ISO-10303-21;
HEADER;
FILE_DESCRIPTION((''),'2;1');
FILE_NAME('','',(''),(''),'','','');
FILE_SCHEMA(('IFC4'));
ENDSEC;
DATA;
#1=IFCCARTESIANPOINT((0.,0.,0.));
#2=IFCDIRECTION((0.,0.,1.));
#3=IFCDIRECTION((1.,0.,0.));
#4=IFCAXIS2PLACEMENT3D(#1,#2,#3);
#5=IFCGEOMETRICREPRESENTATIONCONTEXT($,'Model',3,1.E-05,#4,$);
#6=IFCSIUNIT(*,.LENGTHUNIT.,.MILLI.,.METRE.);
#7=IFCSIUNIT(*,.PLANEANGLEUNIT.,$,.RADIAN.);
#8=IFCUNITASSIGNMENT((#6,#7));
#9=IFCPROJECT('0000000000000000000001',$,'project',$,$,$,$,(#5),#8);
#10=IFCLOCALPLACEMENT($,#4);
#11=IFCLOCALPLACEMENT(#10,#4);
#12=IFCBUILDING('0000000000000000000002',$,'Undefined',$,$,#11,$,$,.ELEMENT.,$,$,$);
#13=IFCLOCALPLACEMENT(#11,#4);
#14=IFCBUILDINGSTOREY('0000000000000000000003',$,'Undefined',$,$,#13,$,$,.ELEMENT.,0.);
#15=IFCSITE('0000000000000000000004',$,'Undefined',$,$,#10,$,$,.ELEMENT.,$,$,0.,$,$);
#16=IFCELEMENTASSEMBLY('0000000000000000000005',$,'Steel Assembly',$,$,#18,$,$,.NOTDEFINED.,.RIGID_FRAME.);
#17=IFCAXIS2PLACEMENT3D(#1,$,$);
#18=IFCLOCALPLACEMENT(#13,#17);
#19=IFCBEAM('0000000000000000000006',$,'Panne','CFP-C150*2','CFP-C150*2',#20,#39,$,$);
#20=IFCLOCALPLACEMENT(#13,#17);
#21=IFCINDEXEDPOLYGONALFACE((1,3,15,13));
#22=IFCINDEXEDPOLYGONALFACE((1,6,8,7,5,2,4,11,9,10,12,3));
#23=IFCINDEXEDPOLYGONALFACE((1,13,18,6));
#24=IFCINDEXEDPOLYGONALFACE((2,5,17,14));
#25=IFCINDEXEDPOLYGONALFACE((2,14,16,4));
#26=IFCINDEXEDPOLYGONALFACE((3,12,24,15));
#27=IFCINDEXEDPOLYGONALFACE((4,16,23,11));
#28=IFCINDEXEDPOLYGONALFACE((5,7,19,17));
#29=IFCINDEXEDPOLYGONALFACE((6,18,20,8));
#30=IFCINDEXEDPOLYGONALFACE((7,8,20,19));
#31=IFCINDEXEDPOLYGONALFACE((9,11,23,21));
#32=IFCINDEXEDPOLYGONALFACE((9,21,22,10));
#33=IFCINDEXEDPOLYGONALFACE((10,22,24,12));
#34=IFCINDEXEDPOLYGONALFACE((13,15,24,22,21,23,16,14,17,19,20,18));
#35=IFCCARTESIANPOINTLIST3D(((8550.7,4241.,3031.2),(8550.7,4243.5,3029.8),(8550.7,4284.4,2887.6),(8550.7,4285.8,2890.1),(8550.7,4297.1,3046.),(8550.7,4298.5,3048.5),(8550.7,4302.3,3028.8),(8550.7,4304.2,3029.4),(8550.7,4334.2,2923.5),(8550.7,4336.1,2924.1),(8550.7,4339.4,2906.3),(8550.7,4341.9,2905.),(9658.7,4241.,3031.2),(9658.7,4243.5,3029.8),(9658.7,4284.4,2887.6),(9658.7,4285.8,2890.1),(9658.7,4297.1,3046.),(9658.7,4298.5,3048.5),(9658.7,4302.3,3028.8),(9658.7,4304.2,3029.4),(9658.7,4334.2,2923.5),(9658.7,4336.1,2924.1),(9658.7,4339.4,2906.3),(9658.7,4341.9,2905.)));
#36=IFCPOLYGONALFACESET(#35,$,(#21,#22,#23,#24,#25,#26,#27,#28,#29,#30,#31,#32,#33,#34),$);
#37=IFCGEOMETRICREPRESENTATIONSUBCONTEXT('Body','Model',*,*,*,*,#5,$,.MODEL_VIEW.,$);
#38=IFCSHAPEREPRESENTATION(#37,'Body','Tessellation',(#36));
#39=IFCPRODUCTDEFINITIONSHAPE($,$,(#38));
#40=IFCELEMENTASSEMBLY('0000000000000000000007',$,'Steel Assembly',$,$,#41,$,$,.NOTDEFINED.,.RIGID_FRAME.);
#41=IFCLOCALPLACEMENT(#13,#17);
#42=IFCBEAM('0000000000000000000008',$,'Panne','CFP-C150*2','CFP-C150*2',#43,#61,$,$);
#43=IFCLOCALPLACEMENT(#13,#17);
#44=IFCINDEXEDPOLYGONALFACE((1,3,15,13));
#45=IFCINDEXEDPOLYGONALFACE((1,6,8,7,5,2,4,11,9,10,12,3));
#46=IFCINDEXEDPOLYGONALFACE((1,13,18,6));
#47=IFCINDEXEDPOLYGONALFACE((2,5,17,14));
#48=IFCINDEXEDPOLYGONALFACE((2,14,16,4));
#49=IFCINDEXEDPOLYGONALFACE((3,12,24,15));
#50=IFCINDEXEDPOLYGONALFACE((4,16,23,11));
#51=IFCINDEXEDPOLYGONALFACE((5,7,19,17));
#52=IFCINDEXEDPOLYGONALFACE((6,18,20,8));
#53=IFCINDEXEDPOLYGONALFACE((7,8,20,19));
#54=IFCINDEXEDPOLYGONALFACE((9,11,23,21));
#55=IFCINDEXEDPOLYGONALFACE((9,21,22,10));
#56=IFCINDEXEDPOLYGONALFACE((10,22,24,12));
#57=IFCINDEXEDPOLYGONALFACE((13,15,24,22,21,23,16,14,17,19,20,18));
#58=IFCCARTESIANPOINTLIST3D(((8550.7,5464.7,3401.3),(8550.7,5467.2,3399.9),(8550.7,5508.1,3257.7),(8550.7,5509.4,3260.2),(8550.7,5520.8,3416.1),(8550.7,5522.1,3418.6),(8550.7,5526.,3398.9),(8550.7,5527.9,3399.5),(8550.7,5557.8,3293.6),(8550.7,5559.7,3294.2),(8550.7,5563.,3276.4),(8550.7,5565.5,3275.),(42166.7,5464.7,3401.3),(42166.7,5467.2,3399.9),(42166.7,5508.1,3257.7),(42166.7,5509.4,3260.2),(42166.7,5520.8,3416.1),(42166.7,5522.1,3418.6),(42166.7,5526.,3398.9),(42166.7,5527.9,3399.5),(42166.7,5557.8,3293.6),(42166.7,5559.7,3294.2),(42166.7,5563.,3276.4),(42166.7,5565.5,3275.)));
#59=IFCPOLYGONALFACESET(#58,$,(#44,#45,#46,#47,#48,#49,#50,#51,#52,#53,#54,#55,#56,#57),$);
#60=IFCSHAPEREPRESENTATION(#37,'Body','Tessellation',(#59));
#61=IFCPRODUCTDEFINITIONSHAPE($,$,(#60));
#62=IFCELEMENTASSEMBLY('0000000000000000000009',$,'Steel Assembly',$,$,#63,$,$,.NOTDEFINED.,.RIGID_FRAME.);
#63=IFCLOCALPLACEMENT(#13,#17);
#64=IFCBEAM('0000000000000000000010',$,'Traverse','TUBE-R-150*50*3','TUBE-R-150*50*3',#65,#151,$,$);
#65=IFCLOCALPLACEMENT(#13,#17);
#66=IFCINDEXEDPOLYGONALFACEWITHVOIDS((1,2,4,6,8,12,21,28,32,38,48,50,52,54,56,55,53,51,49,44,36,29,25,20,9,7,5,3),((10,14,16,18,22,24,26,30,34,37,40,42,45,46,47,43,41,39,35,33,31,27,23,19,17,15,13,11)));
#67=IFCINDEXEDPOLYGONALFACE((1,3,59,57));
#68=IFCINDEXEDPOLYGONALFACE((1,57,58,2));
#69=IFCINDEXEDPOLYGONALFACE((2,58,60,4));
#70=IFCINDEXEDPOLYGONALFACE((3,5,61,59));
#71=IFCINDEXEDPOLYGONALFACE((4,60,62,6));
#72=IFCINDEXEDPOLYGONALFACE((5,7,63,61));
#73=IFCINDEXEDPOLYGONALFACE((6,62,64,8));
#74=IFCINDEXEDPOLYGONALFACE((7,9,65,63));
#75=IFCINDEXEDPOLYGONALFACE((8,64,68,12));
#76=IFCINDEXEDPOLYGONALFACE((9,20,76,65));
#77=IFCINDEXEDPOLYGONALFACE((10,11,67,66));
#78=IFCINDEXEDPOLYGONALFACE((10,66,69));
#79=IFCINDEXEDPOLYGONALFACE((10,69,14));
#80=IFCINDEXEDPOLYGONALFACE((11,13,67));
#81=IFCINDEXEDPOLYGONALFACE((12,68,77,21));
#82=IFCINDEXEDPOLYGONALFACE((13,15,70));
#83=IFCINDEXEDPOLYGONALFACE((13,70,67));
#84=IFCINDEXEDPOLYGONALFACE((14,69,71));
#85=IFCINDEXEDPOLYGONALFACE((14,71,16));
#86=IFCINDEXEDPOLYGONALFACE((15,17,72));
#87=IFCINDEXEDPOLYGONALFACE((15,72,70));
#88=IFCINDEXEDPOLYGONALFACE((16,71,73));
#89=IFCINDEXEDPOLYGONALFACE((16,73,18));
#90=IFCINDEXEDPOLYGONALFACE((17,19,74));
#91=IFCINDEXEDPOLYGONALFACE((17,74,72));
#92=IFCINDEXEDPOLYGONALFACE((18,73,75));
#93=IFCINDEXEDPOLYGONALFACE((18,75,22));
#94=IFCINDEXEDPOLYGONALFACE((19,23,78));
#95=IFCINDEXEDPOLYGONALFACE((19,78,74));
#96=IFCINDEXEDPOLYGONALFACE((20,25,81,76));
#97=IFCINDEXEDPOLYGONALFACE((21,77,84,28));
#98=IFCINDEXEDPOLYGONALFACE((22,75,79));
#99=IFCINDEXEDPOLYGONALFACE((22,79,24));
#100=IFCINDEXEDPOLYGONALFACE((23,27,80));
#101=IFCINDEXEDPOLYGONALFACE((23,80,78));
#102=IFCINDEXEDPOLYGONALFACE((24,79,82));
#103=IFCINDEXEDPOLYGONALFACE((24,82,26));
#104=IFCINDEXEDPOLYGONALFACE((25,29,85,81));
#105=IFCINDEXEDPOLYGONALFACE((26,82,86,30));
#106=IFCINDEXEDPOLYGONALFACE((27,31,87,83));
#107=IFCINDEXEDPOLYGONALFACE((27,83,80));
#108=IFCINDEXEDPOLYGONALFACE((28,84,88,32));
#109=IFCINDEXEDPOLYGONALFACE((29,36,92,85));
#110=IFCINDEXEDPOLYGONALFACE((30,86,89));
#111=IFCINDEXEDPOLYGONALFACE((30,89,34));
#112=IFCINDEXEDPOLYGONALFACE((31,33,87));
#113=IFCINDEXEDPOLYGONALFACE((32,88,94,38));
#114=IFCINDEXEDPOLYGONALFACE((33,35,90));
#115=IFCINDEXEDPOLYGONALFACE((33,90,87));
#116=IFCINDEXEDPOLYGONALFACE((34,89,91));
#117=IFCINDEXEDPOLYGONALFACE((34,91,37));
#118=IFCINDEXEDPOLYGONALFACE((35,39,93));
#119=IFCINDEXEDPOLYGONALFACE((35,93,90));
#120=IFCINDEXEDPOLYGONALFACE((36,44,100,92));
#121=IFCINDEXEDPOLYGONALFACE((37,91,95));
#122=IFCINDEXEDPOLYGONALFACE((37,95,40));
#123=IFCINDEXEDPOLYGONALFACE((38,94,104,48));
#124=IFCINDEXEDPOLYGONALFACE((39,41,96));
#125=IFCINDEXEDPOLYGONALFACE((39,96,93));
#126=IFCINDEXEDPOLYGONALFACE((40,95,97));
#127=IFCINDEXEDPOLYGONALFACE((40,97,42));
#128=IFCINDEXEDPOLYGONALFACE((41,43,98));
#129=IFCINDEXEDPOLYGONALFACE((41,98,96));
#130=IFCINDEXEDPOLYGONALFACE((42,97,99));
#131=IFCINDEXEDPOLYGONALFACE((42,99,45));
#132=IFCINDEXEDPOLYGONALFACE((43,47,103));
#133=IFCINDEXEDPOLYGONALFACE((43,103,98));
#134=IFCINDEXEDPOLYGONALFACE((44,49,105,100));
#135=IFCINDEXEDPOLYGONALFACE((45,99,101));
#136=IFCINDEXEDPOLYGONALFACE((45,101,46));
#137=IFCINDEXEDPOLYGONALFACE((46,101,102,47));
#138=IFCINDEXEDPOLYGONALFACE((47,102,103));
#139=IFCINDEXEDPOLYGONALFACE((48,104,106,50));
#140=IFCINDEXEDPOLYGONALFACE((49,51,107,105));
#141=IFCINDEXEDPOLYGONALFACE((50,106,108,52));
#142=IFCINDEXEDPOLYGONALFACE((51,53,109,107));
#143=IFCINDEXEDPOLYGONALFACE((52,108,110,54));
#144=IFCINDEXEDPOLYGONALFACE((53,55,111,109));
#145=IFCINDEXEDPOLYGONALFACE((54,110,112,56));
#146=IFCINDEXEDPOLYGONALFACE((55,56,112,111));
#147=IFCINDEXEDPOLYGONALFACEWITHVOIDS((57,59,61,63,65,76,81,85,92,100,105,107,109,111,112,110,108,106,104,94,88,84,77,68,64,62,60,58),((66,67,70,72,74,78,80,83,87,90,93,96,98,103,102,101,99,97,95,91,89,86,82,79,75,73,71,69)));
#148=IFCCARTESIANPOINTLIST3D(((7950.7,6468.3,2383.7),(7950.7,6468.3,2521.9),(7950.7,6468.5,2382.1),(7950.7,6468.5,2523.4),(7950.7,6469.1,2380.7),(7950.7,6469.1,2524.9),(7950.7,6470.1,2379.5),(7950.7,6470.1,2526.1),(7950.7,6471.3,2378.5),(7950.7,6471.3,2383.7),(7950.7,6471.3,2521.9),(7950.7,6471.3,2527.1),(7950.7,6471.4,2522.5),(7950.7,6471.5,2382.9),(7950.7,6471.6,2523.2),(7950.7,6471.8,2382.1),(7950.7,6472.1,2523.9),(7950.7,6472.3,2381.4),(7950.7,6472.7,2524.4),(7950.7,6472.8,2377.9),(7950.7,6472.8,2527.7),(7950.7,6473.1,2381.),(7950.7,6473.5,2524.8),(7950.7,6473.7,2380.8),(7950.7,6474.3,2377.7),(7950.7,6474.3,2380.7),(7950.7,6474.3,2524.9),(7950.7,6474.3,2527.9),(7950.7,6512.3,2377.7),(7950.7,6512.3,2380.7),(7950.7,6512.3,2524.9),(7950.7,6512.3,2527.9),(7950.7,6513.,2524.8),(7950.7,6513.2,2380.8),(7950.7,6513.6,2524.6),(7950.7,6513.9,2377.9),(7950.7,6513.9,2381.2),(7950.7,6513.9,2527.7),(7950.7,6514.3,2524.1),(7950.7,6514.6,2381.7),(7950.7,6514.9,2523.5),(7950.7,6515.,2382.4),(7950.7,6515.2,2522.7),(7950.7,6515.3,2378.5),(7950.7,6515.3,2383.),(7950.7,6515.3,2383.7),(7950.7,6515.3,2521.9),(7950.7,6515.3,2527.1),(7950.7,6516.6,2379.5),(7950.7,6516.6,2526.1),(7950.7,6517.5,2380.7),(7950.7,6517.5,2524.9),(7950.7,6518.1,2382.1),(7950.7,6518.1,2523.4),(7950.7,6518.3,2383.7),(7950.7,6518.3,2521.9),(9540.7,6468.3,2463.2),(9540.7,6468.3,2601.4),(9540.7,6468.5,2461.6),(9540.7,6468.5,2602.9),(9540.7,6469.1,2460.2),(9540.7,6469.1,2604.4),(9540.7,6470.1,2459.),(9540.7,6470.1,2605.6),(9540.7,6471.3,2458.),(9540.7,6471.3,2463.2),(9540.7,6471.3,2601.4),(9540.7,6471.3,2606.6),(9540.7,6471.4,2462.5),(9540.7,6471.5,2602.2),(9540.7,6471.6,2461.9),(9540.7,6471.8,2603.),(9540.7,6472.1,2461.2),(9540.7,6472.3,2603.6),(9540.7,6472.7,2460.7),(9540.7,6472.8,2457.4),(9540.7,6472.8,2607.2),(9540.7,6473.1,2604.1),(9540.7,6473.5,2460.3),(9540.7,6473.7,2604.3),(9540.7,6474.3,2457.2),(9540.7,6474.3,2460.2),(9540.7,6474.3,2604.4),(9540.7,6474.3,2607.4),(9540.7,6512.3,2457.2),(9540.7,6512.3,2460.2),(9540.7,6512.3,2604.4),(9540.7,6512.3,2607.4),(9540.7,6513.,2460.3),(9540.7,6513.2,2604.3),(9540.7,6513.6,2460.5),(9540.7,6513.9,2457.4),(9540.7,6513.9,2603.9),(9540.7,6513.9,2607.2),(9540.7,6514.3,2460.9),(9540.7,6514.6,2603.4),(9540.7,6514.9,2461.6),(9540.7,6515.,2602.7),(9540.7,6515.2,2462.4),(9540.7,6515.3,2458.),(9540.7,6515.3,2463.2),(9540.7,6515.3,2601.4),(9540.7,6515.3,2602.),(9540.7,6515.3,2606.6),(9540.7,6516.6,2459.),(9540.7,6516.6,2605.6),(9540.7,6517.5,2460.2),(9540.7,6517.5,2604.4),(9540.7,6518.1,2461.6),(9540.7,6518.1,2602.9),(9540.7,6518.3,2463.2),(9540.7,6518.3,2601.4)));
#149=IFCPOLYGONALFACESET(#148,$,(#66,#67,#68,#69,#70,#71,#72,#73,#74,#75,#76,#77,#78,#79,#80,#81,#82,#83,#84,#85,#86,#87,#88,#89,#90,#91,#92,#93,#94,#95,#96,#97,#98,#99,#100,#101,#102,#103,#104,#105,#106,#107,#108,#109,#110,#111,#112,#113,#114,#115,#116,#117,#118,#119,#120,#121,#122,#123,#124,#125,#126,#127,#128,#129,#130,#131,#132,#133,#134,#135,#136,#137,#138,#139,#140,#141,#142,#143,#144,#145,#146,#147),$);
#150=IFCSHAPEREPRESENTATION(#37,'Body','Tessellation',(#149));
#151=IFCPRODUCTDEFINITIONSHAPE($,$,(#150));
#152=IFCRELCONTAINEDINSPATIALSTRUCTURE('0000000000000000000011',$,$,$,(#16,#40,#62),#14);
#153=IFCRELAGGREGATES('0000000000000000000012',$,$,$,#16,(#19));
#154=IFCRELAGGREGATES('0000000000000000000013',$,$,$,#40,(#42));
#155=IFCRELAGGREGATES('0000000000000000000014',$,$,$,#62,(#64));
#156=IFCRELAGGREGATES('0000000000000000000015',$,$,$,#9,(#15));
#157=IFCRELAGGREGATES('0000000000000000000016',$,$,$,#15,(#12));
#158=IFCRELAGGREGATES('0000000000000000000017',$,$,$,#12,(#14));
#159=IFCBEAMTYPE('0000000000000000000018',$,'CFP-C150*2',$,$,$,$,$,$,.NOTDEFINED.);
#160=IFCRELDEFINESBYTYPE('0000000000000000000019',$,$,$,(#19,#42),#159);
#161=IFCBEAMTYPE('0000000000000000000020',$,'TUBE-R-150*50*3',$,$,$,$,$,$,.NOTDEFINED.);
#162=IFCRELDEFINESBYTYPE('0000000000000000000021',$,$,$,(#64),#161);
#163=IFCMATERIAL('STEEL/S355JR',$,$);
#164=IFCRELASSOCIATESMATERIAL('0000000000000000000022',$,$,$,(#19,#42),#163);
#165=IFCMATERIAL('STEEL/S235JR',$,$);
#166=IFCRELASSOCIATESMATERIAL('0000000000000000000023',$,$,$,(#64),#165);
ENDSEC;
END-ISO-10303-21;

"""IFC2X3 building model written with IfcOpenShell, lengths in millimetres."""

from ifc_helpers import new_model, si_unit, frame, origin_with_axes, origin_2d_with_axis, place, context, subcontext, project, spatial, hollow_rectangle, c_section, extrude, clip, halfspace, material, type_object, element, aggregate, save


model = new_model("IFC2X3")

# Units and contexts
model_context = context("Model", 3, precision=1e-05, world=origin_with_axes())
body_context = subcontext(model_context, "Body", "Model", "MODEL_VIEW")
ifc_project = project(units=[si_unit("LENGTHUNIT", "METRE", prefix="MILLI"), si_unit("PLANEANGLEUNIT", "RADIAN")], contexts=[model_context])

# Site, building, storey
site_placement = place(None, origin_with_axes())
site = spatial("IfcSite", under=ifc_project, at=site_placement, Name="Undefined", CompositionType="ELEMENT", RefElevation=0.0)
building_placement = place(site_placement, origin_with_axes())
building = spatial("IfcBuilding", under=site, at=building_placement, Name="Undefined", CompositionType="ELEMENT")
storey_placement = place(building_placement, origin_with_axes())
storey = spatial("IfcBuildingStorey", under=building, at=storey_placement, Name="Undefined", CompositionType="ELEMENT", Elevation=0.0)

# Element assemblies, beams
assembly_1_placement = place(storey_placement, origin_with_axes())
assembly_1 = element("IfcElementAssembly", 1, at=assembly_1_placement, inside=storey, Name="Steel Assembly", AssemblyPlace="NOTDEFINED", PredefinedType="RIGID_FRAME")
ifc_material_1 = material(Name="STEEL/S355JR")
beam_type_1 = type_object("IfcBeamType", Name="CFP-C150*2", PredefinedType="NOTDEFINED")
beam_1_placement = place(assembly_1_placement, frame((8550.7, 4291.5, 2968.1), z_axis=(0.0, 0.289497, -0.957179), x_axis=(1.0, 0.0, 0.0)))
beam_1 = element("IfcBeam", 2, at=beam_1_placement, type_object=beam_type_1, material=ifc_material_1, Name="Panne", Description="CFP-C150*2", ObjectType="CFP-C150*2", context=body_context, shape_type="SweptSolid", body=[
    extrude(c_section(Depth=150.0, Width=60.0, WallThickness=2.0, Girth=20.0, at=origin_2d_with_axis()), frame((1108.0, 0.0, 0.0), z_axis=(-1.0, 0.0, 0.0), x_axis=(0.0, -1.0, 0.0)), (0.0, 0.0, 1.0), 1108.0),
])
aggregate(assembly_1, [beam_1])
assembly_2_placement = place(storey_placement, origin_with_axes())
assembly_2 = element("IfcElementAssembly", 3, at=assembly_2_placement, inside=storey, Name="Steel Assembly", AssemblyPlace="NOTDEFINED", PredefinedType="RIGID_FRAME")
beam_2_placement = place(assembly_2_placement, frame((8550.7, 5515.1, 3338.1), z_axis=(0.0, 0.289497, -0.957179), x_axis=(1.0, 0.0, 0.0)))
beam_2 = element("IfcBeam", 4, at=beam_2_placement, type_object=beam_type_1, material=ifc_material_1, Name="Panne", Description="CFP-C150*2", ObjectType="CFP-C150*2", context=body_context, shape_type="SweptSolid", body=[
    extrude(c_section(Depth=150.0, Width=60.0, WallThickness=2.0, Girth=20.0, at=origin_2d_with_axis()), frame((33616.0, 0.0, 0.0), z_axis=(-1.0, 0.0, 0.0), x_axis=(0.0, -1.0, 0.0)), (0.0, 0.0, 1.0), 33616.0),
])
aggregate(assembly_2, [beam_2])
assembly_3_placement = place(storey_placement, origin_with_axes())
assembly_3 = element("IfcElementAssembly", 5, at=assembly_3_placement, inside=storey, Name="Steel Assembly", AssemblyPlace="NOTDEFINED", PredefinedType="RIGID_FRAME")
ifc_material_2 = material(Name="STEEL/S235JR")
beam_type_2 = type_object("IfcBeamType", Name="TUBE-R-150*50*3", PredefinedType="NOTDEFINED")
beam_3_placement = place(assembly_3_placement, frame((7952.4, 6493.3, 2452.9), z_axis=(-0.049938, 0.0, 0.998752), x_axis=(0.998752, 0.0, 0.049938)))
beam_3 = element("IfcBeam", 6, at=beam_3_placement, type_object=beam_type_2, material=ifc_material_2, Name="Traverse", Description="TUBE-R-150*50*3", ObjectType="TUBE-R-150*50*3", context=body_context, shape_type="Clipping", body=[
    clip(clip(extrude(hollow_rectangle(XDim=50.0, YDim=150.0, WallThickness=3.0, InnerFilletRadius=3.0, OuterFilletRadius=6.0, at=origin_2d_with_axis()), frame((1597.8, 0.0, 0.0), z_axis=(-1.0, 0.0, 0.0), x_axis=(0.0, -1.0, 0.0)), (0.0, 0.0, 1.0), 1607.1), halfspace(frame((1594.0, 0.0, 75.0), z_axis=(-0.998752, 0.0, 0.049938), x_axis=(0.0, -1.0, 0.0)), True)), halfspace(frame((-2.7, 0.0, -19.9), z_axis=(0.998752, 0.0, -0.049938), x_axis=(0.0, -1.0, 0.0)), True)),
])

aggregate(assembly_3, [beam_3])

save(model, "model.ifc")
